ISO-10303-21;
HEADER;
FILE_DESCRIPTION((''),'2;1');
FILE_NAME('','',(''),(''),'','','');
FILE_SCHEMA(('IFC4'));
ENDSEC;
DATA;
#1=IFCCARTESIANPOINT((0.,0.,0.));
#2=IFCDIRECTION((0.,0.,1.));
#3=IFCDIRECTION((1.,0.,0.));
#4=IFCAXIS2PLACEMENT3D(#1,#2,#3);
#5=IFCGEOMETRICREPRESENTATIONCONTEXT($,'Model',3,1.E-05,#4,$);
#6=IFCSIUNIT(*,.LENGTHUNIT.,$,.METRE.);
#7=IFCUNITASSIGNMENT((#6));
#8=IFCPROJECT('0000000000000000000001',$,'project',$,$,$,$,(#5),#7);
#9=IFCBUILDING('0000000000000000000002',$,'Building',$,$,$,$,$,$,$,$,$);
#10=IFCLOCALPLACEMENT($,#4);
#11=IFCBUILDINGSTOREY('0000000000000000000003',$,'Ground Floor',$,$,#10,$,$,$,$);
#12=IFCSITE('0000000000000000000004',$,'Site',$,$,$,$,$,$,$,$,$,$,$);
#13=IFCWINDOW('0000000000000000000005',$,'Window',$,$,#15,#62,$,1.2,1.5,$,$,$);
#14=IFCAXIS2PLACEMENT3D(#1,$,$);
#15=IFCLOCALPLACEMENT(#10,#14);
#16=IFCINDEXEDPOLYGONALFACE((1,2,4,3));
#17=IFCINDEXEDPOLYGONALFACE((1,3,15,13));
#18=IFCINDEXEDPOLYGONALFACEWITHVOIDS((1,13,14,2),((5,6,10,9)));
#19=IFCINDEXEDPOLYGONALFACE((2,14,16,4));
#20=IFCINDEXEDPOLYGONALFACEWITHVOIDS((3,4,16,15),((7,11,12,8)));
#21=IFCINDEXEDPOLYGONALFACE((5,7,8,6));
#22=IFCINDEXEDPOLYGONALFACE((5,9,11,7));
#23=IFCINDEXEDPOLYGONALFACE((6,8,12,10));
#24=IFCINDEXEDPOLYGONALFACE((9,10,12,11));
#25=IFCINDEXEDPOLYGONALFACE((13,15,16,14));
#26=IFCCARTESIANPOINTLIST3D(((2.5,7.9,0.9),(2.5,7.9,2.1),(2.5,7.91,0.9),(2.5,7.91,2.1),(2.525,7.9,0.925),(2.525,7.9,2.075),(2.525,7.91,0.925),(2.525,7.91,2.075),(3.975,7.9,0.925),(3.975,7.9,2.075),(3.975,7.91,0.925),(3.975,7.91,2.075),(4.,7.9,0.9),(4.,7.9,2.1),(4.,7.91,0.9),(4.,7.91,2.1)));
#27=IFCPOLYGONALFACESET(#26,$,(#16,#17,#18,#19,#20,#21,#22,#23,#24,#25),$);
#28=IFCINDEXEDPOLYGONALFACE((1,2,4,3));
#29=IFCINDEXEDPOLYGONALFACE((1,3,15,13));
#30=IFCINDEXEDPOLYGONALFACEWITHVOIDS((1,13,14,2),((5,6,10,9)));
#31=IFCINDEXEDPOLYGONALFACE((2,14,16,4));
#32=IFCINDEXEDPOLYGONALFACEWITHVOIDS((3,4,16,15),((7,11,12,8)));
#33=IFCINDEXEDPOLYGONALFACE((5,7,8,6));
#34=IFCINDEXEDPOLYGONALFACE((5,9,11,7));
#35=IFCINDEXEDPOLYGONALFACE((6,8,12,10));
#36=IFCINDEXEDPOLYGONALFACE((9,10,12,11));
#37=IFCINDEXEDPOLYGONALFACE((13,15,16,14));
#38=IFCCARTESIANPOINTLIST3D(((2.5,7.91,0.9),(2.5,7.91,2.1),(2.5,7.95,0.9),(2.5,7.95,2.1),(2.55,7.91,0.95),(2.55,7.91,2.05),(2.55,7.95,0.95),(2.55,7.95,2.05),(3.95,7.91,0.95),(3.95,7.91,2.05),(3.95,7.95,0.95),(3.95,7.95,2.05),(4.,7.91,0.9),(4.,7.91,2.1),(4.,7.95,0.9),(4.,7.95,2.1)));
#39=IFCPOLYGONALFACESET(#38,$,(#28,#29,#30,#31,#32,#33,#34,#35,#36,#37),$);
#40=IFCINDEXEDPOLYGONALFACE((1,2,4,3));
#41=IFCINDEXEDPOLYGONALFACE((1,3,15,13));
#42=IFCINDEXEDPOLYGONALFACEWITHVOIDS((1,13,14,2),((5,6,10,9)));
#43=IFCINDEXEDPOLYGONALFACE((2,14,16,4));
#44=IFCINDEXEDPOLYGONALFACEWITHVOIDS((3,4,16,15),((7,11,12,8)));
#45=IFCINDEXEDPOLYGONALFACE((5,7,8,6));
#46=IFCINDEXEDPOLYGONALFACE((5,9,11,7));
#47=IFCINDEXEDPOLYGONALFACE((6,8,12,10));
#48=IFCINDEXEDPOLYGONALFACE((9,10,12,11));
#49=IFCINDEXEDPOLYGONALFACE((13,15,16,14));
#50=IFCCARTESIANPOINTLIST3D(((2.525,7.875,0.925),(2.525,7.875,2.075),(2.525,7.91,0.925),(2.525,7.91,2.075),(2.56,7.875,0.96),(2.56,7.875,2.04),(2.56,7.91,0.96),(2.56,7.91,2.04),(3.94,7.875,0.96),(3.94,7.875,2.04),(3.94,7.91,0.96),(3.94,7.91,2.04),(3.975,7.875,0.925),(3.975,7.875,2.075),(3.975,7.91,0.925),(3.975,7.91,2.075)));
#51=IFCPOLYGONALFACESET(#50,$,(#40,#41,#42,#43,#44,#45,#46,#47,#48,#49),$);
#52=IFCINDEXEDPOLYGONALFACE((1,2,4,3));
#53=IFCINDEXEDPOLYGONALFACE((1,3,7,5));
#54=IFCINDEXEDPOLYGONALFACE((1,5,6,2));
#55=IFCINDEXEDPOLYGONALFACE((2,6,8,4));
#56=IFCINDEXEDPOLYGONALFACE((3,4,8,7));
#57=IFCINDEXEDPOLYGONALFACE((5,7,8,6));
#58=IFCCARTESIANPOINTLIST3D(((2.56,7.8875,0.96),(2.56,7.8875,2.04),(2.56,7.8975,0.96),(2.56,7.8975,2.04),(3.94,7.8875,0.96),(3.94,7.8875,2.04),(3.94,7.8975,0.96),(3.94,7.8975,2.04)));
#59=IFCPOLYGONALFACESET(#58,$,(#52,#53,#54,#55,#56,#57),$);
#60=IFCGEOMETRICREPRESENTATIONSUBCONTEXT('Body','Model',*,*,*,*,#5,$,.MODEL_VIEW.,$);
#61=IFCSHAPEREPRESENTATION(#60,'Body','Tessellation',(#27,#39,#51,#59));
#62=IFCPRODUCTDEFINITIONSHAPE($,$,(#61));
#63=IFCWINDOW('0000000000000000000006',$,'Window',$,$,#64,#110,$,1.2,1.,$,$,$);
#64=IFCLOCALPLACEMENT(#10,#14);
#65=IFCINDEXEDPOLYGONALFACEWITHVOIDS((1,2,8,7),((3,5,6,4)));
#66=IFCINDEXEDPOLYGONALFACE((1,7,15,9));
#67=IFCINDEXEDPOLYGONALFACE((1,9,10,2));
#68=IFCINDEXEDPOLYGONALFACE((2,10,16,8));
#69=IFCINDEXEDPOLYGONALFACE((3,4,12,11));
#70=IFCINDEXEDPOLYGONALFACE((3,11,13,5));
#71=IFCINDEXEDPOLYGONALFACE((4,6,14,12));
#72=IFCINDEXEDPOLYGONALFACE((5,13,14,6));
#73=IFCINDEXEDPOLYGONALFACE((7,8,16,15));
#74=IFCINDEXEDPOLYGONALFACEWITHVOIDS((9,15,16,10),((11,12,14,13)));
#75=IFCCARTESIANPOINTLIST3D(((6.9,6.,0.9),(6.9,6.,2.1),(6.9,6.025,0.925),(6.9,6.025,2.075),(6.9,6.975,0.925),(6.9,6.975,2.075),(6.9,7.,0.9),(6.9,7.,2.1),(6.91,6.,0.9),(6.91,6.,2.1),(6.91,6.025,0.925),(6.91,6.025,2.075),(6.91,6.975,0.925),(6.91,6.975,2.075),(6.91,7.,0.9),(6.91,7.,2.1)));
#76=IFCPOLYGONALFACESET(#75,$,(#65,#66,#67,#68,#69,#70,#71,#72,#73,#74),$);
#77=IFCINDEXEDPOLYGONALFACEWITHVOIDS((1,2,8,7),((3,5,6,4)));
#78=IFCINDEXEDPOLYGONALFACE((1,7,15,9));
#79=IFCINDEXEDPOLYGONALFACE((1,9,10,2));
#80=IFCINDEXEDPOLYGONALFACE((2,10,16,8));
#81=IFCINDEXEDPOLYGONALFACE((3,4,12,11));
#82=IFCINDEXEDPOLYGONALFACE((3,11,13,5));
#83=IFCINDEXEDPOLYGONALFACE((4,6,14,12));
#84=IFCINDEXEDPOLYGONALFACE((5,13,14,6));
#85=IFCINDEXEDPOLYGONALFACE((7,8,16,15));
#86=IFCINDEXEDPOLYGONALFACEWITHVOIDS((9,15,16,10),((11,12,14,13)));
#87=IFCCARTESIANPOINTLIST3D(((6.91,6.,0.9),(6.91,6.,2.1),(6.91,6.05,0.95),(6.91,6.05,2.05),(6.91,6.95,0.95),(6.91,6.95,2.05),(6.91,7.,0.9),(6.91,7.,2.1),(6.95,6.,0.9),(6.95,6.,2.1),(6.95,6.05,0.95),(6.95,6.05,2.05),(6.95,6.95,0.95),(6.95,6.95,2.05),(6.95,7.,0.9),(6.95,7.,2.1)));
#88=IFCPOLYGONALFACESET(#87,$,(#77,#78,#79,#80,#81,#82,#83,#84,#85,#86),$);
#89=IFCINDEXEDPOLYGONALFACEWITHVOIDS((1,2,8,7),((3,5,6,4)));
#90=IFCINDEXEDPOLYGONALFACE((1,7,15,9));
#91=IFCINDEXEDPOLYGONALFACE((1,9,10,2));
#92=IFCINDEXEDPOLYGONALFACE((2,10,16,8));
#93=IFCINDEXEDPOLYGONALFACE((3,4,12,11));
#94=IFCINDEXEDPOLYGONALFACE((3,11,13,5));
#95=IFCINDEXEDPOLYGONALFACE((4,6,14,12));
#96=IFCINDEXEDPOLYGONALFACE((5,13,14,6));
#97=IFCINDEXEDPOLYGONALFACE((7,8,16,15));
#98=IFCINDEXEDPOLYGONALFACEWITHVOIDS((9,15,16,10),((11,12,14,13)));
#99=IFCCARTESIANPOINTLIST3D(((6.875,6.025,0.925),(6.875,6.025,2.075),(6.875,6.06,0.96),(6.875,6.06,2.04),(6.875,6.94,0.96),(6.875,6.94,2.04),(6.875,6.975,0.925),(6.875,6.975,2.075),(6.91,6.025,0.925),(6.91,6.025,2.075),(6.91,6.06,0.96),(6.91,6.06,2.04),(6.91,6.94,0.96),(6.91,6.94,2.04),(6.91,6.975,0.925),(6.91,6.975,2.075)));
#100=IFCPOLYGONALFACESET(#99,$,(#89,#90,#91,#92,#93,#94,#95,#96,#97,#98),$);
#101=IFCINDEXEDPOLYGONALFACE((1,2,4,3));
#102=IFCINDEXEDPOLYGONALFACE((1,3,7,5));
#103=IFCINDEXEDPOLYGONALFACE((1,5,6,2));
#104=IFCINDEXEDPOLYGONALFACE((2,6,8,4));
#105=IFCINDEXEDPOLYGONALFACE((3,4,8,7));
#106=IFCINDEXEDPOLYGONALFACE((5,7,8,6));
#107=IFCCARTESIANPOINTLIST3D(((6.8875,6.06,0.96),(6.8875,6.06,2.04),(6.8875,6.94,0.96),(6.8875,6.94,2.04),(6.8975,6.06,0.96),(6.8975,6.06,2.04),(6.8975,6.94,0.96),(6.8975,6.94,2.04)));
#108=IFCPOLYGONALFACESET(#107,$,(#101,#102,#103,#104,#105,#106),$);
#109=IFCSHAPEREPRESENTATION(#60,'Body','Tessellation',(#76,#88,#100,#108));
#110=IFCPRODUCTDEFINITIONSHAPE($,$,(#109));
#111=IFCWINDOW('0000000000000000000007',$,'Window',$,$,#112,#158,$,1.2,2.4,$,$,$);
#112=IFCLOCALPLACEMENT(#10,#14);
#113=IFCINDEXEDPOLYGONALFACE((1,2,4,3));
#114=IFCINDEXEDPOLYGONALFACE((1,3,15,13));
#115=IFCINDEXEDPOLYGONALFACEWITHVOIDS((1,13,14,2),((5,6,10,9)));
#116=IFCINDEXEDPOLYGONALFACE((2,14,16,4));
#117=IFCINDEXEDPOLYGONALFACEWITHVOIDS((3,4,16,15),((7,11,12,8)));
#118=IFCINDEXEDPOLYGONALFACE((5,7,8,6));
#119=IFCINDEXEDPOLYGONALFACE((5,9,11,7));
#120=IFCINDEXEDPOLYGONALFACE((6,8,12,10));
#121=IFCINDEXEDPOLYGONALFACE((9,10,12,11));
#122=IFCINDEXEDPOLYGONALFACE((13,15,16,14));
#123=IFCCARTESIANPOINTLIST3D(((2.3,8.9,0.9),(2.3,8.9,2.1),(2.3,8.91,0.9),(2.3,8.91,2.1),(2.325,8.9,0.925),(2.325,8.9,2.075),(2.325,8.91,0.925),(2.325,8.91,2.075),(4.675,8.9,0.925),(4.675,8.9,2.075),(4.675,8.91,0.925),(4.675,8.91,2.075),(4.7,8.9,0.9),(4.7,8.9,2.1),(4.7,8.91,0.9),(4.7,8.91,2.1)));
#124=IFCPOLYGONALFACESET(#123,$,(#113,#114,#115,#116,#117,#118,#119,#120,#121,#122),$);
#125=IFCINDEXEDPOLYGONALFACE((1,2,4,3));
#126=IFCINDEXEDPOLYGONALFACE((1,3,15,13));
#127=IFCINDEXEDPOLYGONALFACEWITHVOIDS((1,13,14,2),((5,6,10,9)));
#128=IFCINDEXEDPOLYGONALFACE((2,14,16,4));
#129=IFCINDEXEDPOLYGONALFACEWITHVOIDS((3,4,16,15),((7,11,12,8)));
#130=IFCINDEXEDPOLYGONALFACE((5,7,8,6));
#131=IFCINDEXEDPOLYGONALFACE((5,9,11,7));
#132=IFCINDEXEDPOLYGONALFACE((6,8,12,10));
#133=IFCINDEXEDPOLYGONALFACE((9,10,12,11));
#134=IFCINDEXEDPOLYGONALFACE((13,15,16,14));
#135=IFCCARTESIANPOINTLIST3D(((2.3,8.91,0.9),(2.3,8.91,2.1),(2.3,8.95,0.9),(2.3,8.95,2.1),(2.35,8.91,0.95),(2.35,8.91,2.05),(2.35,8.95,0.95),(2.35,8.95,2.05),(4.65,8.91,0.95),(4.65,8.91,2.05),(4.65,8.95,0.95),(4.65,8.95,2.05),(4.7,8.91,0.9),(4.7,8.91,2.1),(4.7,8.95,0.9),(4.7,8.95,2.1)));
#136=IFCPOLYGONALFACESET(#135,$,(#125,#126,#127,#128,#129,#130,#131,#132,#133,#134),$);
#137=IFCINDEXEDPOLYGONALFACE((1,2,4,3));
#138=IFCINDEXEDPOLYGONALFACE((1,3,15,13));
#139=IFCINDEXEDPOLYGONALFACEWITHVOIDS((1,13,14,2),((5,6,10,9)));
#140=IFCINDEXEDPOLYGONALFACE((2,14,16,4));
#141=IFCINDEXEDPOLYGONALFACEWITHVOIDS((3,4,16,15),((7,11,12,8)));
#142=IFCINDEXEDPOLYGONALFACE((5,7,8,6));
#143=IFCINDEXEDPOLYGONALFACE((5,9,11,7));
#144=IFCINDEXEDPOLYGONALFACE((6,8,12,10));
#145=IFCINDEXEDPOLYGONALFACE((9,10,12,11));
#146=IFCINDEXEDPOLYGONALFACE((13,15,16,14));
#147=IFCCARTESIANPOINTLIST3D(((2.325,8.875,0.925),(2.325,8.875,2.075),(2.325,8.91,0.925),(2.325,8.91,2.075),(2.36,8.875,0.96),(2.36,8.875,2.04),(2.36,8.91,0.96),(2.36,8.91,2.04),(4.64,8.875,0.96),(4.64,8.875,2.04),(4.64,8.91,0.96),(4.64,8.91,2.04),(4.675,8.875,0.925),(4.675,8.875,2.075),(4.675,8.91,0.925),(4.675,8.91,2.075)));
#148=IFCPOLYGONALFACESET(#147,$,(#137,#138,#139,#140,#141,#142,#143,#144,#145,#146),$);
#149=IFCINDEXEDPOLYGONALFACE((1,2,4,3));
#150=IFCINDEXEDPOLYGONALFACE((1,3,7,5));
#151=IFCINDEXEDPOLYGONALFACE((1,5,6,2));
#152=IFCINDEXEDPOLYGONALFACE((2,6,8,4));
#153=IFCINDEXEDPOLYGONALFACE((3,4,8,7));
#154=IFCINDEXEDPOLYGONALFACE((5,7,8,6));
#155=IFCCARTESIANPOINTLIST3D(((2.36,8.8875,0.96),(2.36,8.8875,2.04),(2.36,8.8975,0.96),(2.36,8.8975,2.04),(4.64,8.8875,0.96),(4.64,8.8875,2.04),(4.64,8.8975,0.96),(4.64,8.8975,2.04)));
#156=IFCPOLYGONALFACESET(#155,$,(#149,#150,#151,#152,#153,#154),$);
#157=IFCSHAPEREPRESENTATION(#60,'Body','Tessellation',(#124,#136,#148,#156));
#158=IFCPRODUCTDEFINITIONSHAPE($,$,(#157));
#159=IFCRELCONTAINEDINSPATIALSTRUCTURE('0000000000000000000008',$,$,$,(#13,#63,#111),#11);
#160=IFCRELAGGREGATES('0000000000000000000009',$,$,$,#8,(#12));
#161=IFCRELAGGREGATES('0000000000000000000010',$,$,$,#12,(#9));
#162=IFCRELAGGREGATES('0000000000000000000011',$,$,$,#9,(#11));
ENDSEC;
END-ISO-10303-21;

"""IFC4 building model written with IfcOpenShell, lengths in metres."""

from ifc_helpers import new_model, si_unit, frame, origin_with_axes, place, context, subcontext, project, spatial, line, indexed_curve, outline, extrude, element, save


model = new_model("IFC4")

# Units and contexts
model_context = context("Model", 3, precision=1e-05, world=origin_with_axes())
body_context = subcontext(model_context, "Body", "Model", "MODEL_VIEW")
ifc_project = project(units=[si_unit("LENGTHUNIT", "METRE")], contexts=[model_context])

# Site, building, storey
site = spatial("IfcSite", under=ifc_project, Name="Site")
building = spatial("IfcBuilding", under=site, Name="Building")
storey_placement = place(None, origin_with_axes())
storey = spatial("IfcBuildingStorey", under=building, at=storey_placement, Name="Ground Floor")

# Windows
window_1_placement = place(storey_placement, frame((4.0, 8.0, 0.9), z_axis=(0.0, 0.0, 1.0), x_axis=(-1.0, 0.0, 0.0)))
element("IfcWindow", 1, at=window_1_placement, inside=storey, Name="Window", OverallHeight=1.2, OverallWidth=1.5, context=body_context, shape_type="SweptSolid", body=[
    extrude(outline(indexed_curve([(0.0, 0.0), (1.5, 0.0), (1.5, 1.2), (0.0, 1.2)], segments=[line(1, 2, 3, 4, 1)]), holes=[indexed_curve([(0.025, 0.025), (1.475, 0.025), (1.475, 1.175), (0.025, 1.175)], segments=[line(1, 2, 3, 4, 1)])]), frame((0.0, 0.09, 0.0), z_axis=(0.0, -1.0, 0.0), x_axis=(1.0, 0.0, 0.0)), (0.0, 0.0, -1.0), 0.01),
    extrude(outline(indexed_curve([(0.0, 0.0), (1.5, 0.0), (1.5, 1.2), (0.0, 1.2)], segments=[line(1, 2, 3, 4, 1)]), holes=[indexed_curve([(0.05, 0.05), (1.45, 0.05), (1.45, 1.15), (0.05, 1.15)], segments=[line(1, 2, 3, 4, 1)])]), frame((0.0, 0.05, 0.0), z_axis=(0.0, -1.0, 0.0), x_axis=(1.0, 0.0, 0.0)), (0.0, 0.0, -1.0), 0.04),
    extrude(outline(indexed_curve([(0.0, 0.0), (1.45, 0.0), (1.45, 1.15), (0.0, 1.15)], segments=[line(1, 2, 3, 4, 1)]), holes=[indexed_curve([(0.035, 0.035), (1.415, 0.035), (1.415, 1.115), (0.035, 1.115)], segments=[line(1, 2, 3, 4, 1)])]), frame((0.025, 0.09, 0.025), z_axis=(0.0, -1.0, 0.0), x_axis=(1.0, 0.0, 0.0)), (0.0, 0.0, -1.0), 0.035),
    extrude(outline(indexed_curve([(0.035, 0.035), (1.415, 0.035), (1.415, 1.115), (0.035, 1.115)], segments=[line(1, 2, 3, 4, 1)])), frame((0.025, 0.1025, 0.025), z_axis=(0.0, -1.0, 0.0), x_axis=(1.0, 0.0, 0.0)), (0.0, 0.0, -1.0), 0.01),
])
window_2_placement = place(storey_placement, frame((7.0, 6.0, 0.9), z_axis=(0.0, 0.0, 1.0), x_axis=(0.0, 1.0, 0.0)))
element("IfcWindow", 2, at=window_2_placement, inside=storey, Name="Window", OverallHeight=1.2, OverallWidth=1.0, context=body_context, shape_type="SweptSolid", body=[
    extrude(outline(indexed_curve([(0.0, 0.0), (1.0, 0.0), (1.0, 1.2), (0.0, 1.2)], segments=[line(1, 2, 3, 4, 1)]), holes=[indexed_curve([(0.025, 0.025), (0.975, 0.025), (0.975, 1.175), (0.025, 1.175)], segments=[line(1, 2, 3, 4, 1)])]), frame((0.0, 0.09, 0.0), z_axis=(0.0, -1.0, 0.0), x_axis=(1.0, 0.0, 0.0)), (0.0, 0.0, -1.0), 0.01),
    extrude(outline(indexed_curve([(0.0, 0.0), (1.0, 0.0), (1.0, 1.2), (0.0, 1.2)], segments=[line(1, 2, 3, 4, 1)]), holes=[indexed_curve([(0.05, 0.05), (0.95, 0.05), (0.95, 1.15), (0.05, 1.15)], segments=[line(1, 2, 3, 4, 1)])]), frame((0.0, 0.05, 0.0), z_axis=(0.0, -1.0, 0.0), x_axis=(1.0, 0.0, 0.0)), (0.0, 0.0, -1.0), 0.04),
    extrude(outline(indexed_curve([(0.0, 0.0), (0.95, 0.0), (0.95, 1.15), (0.0, 1.15)], segments=[line(1, 2, 3, 4, 1)]), holes=[indexed_curve([(0.035, 0.035), (0.915, 0.035), (0.915, 1.115), (0.035, 1.115)], segments=[line(1, 2, 3, 4, 1)])]), frame((0.025, 0.09, 0.025), z_axis=(0.0, -1.0, 0.0), x_axis=(1.0, 0.0, 0.0)), (0.0, 0.0, -1.0), 0.035),
    extrude(outline(indexed_curve([(0.035, 0.035), (0.915, 0.035), (0.915, 1.115), (0.035, 1.115)], segments=[line(1, 2, 3, 4, 1)])), frame((0.025, 0.1025, 0.025), z_axis=(0.0, -1.0, 0.0), x_axis=(1.0, 0.0, 0.0)), (0.0, 0.0, -1.0), 0.01),
])
window_3_placement = place(storey_placement, frame((4.7, 9.0, 0.9), z_axis=(0.0, 0.0, 1.0), x_axis=(-1.0, 0.0, 0.0)))
element("IfcWindow", 3, at=window_3_placement, inside=storey, Name="Window", OverallHeight=1.2, OverallWidth=2.4, context=body_context, shape_type="SweptSolid", body=[
    extrude(outline(indexed_curve([(0.0, 0.0), (2.4, 0.0), (2.4, 1.2), (0.0, 1.2)], segments=[line(1, 2, 3, 4, 1)]), holes=[indexed_curve([(0.025, 0.025), (2.375, 0.025), (2.375, 1.175), (0.025, 1.175)], segments=[line(1, 2, 3, 4, 1)])]), frame((0.0, 0.09, 0.0), z_axis=(0.0, -1.0, 0.0), x_axis=(1.0, 0.0, 0.0)), (0.0, 0.0, -1.0), 0.01),
    extrude(outline(indexed_curve([(0.0, 0.0), (2.4, 0.0), (2.4, 1.2), (0.0, 1.2)], segments=[line(1, 2, 3, 4, 1)]), holes=[indexed_curve([(0.05, 0.05), (2.35, 0.05), (2.35, 1.15), (0.05, 1.15)], segments=[line(1, 2, 3, 4, 1)])]), frame((0.0, 0.05, 0.0), z_axis=(0.0, -1.0, 0.0), x_axis=(1.0, 0.0, 0.0)), (0.0, 0.0, -1.0), 0.04),
    extrude(outline(indexed_curve([(0.0, 0.0), (2.35, 0.0), (2.35, 1.15), (0.0, 1.15)], segments=[line(1, 2, 3, 4, 1)]), holes=[indexed_curve([(0.035, 0.035), (2.315, 0.035), (2.315, 1.115), (0.035, 1.115)], segments=[line(1, 2, 3, 4, 1)])]), frame((0.025, 0.09, 0.025), z_axis=(0.0, -1.0, 0.0), x_axis=(1.0, 0.0, 0.0)), (0.0, 0.0, -1.0), 0.035),
    extrude(outline(indexed_curve([(0.035, 0.035), (2.315, 0.035), (2.315, 1.115), (0.035, 1.115)], segments=[line(1, 2, 3, 4, 1)])), frame((0.025, 0.1025, 0.025), z_axis=(0.0, -1.0, 0.0), x_axis=(1.0, 0.0, 0.0)), (0.0, 0.0, -1.0), 0.01),
])

save(model, "model.ifc")
